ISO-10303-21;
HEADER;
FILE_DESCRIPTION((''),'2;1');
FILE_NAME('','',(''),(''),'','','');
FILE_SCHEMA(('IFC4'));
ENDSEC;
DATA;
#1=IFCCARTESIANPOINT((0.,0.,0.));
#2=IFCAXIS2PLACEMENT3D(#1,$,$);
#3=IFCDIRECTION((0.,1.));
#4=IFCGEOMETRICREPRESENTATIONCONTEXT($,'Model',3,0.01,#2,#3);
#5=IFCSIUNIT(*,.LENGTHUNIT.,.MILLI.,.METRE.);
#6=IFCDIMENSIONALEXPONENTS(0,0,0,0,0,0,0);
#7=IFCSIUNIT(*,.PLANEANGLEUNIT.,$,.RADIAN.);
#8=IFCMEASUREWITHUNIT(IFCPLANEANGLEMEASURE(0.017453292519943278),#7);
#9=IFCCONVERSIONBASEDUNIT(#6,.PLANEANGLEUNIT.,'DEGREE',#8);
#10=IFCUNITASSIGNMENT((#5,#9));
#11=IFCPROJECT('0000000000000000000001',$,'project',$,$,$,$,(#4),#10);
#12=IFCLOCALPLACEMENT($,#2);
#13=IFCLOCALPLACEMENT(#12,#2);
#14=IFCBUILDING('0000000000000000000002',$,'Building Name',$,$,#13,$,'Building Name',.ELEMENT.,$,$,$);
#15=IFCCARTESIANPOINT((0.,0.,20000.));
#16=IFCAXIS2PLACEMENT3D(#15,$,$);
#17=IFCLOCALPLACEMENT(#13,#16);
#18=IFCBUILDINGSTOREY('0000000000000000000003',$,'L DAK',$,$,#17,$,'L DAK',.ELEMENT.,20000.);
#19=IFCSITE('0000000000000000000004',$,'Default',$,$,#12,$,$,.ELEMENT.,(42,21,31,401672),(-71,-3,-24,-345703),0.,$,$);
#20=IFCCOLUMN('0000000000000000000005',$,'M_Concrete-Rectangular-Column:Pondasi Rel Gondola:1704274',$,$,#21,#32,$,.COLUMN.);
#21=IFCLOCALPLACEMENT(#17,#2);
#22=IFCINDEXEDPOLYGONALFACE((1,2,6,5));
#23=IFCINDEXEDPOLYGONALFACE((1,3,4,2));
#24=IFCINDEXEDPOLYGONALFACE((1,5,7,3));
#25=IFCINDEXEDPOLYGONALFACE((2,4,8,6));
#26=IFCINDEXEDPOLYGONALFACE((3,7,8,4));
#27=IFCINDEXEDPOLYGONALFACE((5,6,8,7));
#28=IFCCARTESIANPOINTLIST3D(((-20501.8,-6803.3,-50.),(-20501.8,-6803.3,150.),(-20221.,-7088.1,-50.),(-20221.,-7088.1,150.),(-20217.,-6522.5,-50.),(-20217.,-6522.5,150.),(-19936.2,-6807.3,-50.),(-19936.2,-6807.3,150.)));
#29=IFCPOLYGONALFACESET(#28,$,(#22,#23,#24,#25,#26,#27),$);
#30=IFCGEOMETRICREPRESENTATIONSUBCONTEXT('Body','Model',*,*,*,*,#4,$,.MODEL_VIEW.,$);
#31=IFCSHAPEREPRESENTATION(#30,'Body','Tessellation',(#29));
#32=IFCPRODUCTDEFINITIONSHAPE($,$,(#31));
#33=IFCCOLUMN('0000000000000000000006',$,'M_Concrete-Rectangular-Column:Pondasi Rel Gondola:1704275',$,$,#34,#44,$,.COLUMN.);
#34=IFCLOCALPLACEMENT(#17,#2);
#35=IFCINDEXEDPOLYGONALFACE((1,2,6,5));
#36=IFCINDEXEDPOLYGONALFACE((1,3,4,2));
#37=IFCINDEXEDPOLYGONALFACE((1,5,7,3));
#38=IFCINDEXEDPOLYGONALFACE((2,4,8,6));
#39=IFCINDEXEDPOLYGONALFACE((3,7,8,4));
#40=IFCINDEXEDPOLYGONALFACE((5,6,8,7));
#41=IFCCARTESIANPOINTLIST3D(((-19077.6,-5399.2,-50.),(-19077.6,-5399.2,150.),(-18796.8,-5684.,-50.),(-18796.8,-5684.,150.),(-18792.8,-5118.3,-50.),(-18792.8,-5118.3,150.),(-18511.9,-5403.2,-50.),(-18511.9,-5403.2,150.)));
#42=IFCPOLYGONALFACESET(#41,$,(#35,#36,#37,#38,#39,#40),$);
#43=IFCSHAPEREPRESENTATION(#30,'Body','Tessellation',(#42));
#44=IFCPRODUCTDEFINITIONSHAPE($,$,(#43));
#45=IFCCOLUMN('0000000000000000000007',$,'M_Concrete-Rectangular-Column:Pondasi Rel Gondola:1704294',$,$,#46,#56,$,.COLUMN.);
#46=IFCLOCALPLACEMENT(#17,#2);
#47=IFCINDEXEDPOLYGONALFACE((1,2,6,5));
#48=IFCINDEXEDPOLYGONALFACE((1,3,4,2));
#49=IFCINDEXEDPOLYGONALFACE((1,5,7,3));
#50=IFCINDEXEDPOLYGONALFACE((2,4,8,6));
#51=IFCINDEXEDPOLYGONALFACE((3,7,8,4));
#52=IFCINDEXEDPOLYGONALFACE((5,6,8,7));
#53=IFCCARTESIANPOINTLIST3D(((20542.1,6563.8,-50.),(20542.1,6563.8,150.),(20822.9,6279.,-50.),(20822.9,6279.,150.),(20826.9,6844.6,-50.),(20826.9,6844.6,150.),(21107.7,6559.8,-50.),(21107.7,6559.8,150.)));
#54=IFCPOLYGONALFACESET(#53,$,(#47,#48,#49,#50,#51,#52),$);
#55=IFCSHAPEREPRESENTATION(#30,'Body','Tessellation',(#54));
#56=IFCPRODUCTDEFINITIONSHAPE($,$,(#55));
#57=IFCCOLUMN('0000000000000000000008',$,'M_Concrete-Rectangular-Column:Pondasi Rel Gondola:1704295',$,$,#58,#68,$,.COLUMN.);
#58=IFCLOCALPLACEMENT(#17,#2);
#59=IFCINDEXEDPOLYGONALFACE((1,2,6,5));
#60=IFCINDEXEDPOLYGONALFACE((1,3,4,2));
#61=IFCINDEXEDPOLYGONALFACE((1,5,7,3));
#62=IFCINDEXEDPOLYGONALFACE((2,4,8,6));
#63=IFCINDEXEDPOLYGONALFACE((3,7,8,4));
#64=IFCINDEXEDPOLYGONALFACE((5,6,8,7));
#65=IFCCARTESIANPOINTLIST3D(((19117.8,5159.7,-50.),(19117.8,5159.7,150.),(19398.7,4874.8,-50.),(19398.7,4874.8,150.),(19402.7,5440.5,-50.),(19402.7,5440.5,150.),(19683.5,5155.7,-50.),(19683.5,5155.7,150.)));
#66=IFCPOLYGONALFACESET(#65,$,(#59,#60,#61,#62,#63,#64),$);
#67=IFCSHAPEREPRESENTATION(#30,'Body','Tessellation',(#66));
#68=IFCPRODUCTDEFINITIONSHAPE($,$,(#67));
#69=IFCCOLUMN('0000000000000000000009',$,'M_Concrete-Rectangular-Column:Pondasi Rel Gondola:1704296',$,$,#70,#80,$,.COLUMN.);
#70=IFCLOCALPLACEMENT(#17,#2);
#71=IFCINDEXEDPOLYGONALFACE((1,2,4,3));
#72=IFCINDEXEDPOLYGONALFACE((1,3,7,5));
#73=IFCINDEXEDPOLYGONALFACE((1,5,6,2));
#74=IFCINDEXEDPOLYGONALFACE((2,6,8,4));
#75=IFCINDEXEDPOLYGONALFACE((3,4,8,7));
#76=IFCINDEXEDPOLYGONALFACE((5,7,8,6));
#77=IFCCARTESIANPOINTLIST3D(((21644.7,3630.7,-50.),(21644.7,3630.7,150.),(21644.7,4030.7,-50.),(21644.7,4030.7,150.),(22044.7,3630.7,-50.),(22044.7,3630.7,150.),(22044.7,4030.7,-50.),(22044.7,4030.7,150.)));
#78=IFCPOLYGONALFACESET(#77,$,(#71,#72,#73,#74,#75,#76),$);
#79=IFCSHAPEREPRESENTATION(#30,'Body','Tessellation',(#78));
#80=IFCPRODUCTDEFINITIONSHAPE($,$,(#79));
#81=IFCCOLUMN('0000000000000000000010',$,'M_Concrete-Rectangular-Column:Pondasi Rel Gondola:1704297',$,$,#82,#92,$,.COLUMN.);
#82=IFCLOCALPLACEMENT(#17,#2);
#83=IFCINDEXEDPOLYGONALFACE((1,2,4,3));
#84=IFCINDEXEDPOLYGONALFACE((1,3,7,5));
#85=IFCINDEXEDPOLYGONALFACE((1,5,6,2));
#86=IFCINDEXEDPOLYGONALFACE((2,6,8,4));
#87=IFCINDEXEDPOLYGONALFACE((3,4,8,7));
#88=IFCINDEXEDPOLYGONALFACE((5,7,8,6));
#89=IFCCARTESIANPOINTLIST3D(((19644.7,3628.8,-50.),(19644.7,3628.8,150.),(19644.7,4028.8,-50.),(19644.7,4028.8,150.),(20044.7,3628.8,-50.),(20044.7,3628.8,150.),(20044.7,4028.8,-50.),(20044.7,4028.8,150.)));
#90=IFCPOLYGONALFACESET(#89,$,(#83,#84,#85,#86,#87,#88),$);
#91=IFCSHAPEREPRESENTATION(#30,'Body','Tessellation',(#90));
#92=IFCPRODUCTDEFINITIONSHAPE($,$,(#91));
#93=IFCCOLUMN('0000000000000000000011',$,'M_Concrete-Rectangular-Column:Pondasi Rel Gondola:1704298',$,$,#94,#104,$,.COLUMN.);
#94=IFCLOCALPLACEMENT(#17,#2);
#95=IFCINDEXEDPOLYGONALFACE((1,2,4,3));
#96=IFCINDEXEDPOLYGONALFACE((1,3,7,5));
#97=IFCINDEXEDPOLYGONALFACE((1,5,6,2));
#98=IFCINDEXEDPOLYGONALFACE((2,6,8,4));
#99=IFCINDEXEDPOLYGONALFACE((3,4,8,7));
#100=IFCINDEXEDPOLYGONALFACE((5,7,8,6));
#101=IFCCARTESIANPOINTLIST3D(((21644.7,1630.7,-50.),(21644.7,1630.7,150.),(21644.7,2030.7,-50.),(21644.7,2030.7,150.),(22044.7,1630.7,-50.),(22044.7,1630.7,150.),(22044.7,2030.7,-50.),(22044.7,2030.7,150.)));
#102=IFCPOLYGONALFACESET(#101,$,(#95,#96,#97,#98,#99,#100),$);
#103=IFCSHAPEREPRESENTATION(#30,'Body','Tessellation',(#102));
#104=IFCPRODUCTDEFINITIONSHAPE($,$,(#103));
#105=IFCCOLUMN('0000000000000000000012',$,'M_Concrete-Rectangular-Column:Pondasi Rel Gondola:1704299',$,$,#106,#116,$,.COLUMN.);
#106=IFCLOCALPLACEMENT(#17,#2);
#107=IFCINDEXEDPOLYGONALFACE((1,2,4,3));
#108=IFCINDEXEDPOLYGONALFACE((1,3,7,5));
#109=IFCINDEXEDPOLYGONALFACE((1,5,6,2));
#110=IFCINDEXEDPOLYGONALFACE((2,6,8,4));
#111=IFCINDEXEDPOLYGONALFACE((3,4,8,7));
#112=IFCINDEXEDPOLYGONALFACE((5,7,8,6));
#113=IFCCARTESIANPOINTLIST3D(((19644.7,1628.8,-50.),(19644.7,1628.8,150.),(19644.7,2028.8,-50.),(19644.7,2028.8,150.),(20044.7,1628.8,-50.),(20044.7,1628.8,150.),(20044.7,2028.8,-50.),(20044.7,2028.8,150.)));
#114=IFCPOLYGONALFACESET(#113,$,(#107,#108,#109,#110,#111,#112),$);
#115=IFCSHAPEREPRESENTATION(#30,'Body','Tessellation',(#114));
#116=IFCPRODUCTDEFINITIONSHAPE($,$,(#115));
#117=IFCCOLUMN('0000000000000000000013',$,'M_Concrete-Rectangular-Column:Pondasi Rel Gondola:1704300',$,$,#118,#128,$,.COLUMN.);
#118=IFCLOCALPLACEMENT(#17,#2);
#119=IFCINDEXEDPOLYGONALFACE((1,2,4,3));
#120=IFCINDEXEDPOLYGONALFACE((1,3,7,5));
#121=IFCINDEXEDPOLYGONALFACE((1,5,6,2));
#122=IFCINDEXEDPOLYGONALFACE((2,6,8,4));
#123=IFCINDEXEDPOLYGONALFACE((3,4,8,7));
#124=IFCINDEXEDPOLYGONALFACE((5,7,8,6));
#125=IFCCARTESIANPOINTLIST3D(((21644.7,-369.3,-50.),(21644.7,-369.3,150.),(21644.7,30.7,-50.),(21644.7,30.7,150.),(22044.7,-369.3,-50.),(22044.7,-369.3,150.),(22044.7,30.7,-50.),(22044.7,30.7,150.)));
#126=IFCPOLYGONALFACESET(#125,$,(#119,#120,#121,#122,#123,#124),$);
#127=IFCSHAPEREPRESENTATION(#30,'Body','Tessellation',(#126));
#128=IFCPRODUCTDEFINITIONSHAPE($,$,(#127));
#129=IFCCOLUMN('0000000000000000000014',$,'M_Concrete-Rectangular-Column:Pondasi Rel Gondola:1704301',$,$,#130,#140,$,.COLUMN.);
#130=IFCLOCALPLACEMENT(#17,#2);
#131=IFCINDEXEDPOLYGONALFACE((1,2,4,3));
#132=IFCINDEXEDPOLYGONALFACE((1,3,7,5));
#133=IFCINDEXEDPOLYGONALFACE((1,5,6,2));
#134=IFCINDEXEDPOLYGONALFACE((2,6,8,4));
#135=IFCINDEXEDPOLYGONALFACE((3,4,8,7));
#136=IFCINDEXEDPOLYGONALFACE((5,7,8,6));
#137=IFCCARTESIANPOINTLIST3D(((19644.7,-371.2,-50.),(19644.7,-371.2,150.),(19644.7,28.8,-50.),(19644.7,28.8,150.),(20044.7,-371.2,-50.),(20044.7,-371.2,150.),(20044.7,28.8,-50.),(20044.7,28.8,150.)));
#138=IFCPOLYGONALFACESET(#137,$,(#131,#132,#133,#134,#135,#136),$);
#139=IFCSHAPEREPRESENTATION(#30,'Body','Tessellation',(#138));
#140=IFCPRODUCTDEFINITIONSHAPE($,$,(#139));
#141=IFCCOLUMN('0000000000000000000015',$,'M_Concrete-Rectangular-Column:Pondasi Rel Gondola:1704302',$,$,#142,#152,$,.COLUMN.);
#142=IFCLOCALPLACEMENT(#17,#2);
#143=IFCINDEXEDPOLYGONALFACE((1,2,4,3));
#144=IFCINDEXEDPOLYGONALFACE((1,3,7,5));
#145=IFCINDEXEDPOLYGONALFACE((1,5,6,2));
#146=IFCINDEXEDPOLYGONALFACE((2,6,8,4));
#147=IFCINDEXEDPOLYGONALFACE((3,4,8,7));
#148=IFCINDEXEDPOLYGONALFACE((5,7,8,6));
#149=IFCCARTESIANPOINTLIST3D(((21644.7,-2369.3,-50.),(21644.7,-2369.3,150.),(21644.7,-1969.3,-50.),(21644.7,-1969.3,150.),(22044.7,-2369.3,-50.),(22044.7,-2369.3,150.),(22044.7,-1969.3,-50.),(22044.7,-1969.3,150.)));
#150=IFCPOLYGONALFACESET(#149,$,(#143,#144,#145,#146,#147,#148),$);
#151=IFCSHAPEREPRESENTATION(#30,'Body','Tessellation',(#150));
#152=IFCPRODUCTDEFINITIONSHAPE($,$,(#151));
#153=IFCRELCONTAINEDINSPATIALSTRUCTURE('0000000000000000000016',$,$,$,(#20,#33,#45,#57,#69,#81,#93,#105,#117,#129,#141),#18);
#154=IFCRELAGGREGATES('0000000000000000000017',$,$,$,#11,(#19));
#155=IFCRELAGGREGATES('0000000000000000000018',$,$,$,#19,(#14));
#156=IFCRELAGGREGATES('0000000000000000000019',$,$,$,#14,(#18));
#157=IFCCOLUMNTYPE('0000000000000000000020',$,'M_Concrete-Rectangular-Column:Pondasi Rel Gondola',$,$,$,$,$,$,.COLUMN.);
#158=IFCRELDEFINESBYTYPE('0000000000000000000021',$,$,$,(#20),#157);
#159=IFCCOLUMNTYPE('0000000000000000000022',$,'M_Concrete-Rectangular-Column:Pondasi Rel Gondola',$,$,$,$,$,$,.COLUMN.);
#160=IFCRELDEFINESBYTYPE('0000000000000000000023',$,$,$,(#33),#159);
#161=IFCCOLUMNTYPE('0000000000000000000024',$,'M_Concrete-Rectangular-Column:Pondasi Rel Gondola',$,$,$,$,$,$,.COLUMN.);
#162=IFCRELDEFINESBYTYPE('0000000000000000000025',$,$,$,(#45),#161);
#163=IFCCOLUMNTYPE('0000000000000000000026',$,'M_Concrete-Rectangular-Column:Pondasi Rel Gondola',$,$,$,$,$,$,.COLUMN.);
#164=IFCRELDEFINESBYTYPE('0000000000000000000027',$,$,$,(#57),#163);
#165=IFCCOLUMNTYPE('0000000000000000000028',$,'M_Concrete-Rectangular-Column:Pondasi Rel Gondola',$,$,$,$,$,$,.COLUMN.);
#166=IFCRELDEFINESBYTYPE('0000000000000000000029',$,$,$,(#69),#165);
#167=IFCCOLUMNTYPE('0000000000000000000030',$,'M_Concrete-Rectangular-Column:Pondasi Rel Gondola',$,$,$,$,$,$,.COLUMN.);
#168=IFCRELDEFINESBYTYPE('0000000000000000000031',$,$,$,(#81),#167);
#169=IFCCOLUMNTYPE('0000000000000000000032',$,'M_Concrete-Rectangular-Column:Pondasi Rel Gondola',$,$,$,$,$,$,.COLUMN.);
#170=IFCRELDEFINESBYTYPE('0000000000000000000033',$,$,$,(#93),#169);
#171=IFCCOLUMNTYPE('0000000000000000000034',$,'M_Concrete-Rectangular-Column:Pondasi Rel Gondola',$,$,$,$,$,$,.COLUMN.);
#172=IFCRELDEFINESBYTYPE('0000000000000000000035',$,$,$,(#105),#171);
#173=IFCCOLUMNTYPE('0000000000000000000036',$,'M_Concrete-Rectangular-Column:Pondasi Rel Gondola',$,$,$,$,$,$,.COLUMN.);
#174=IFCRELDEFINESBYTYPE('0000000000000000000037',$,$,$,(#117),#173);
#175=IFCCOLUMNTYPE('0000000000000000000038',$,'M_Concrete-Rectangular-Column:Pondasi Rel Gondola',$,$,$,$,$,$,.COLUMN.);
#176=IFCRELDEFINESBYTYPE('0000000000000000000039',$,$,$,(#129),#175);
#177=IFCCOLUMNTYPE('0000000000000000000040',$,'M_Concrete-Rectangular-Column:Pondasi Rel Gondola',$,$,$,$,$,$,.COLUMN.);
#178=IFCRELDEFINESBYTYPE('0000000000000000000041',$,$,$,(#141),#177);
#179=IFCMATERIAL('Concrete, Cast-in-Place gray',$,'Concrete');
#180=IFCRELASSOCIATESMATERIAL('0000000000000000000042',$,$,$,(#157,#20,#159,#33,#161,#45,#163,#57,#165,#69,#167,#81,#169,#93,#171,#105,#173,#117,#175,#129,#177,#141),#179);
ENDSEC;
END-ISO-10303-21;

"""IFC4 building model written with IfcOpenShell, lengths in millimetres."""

from ifc_helpers import new_model, entity, si_unit, converted_unit, direction, frame, origin, place, context, subcontext, project, spatial, indexed_curve, outline, extrude, source, transform, mapped, material, type_object, type_shapes, element, save


model = new_model("IFC4")

# Units and contexts
model_context = context("Model", 3, precision=0.01, world=origin(), true_north=direction((0.0, 1.0)))
body_context = subcontext(model_context, "Body", "Model", "MODEL_VIEW")
ifc_project = project(units=[si_unit("LENGTHUNIT", "METRE", prefix="MILLI"), converted_unit("PLANEANGLEUNIT", "DEGREE", entity("IfcPlaneAngleMeasure", 0.017453292519943278), si_unit("PLANEANGLEUNIT", "RADIAN"), dimensions=[0, 0, 0, 0, 0, 0, 0])], contexts=[model_context])

# Site, building, storey
site_placement = place(None, origin())
site = spatial("IfcSite", under=ifc_project, at=site_placement, Name="Default", CompositionType="ELEMENT", RefLatitude=(42, 21, 31, 401672), RefLongitude=(-71, -3, -24, -345703), RefElevation=0.0)
building_placement = place(site_placement, origin())
building = spatial("IfcBuilding", under=site, at=building_placement, Name="Building Name", LongName="Building Name", CompositionType="ELEMENT")
storey_placement = place(building_placement, frame((0.0, 0.0, 20000.0)))
storey = spatial("IfcBuildingStorey", under=building, at=storey_placement, Name="L DAK", LongName="L DAK", CompositionType="ELEMENT", Elevation=20000.0)

# Columns
ifc_material = material(Name="Concrete, Cast-in-Place gray", Category="Concrete")
column_type_1 = type_object("IfcColumnType", Name="M_Concrete-Rectangular-Column:Pondasi Rel Gondola", PredefinedType="COLUMN", material=ifc_material)
shared_shape_1 = source(origin(), body_context, "Body", "SweptSolid", [
    extrude(outline(indexed_curve([(-200.0, -200.0), (200.0, -200.0), (200.0, 200.0), (-200.0, 200.0), (-200.0, -200.0)], self_intersect=False)), frame((-20219.0, -6805.3, 19950.0), z_axis=(0.0, 0.0, 1.0), x_axis=(0.712114, 0.702064, 0.0)), (0.0, 0.0, 1.0), 200.0),
])
type_shapes(column_type_1, [shared_shape_1])
column_1_placement = place(storey_placement, frame((0.0, 0.0, -20000.0)))
element("IfcColumn", 1, at=column_1_placement, inside=storey, type_object=column_type_1, material=ifc_material, Name="M_Concrete-Rectangular-Column:Pondasi Rel Gondola:1704274", PredefinedType="COLUMN", context=body_context, shape_type="MappedRepresentation", body=[
    mapped(shared_shape_1, transform((0.0, 0.0, 0.0), scale=1.0)),
])
column_type_2 = type_object("IfcColumnType", Name="M_Concrete-Rectangular-Column:Pondasi Rel Gondola", PredefinedType="COLUMN", material=ifc_material)
shared_shape_2 = source(origin(), body_context, "Body", "SweptSolid", [
    extrude(outline(indexed_curve([(-200.0, -200.0), (200.0, -200.0), (200.0, 200.0), (-200.0, 200.0), (-200.0, -200.0)], self_intersect=False)), frame((-18794.8, -5401.2, 19950.0), z_axis=(0.0, 0.0, 1.0), x_axis=(0.712114, 0.702064, 0.0)), (0.0, 0.0, 1.0), 200.0),
])
type_shapes(column_type_2, [shared_shape_2])
column_2_placement = place(storey_placement, frame((0.0, 0.0, -20000.0)))
element("IfcColumn", 2, at=column_2_placement, inside=storey, type_object=column_type_2, material=ifc_material, Name="M_Concrete-Rectangular-Column:Pondasi Rel Gondola:1704275", PredefinedType="COLUMN", context=body_context, shape_type="MappedRepresentation", body=[
    mapped(shared_shape_2, transform((0.0, 0.0, 0.0), scale=1.0)),
])
column_type_3 = type_object("IfcColumnType", Name="M_Concrete-Rectangular-Column:Pondasi Rel Gondola", PredefinedType="COLUMN", material=ifc_material)
shared_shape_3 = source(origin(), body_context, "Body", "SweptSolid", [
    extrude(outline(indexed_curve([(-200.0, -200.0), (200.0, -200.0), (200.0, 200.0), (-200.0, 200.0), (-200.0, -200.0)], self_intersect=False)), frame((20824.9, 6561.8, 19950.0), z_axis=(0.0, 0.0, 1.0), x_axis=(-0.712114, -0.702064, 0.0)), (0.0, 0.0, 1.0), 200.0),
])
type_shapes(column_type_3, [shared_shape_3])
column_3_placement = place(storey_placement, frame((0.0, 0.0, -20000.0)))
element("IfcColumn", 3, at=column_3_placement, inside=storey, type_object=column_type_3, material=ifc_material, Name="M_Concrete-Rectangular-Column:Pondasi Rel Gondola:1704294", PredefinedType="COLUMN", context=body_context, shape_type="MappedRepresentation", body=[
    mapped(shared_shape_3, transform((0.0, 0.0, 0.0), scale=1.0)),
])
column_type_4 = type_object("IfcColumnType", Name="M_Concrete-Rectangular-Column:Pondasi Rel Gondola", PredefinedType="COLUMN", material=ifc_material)
shared_shape_4 = source(origin(), body_context, "Body", "SweptSolid", [
    extrude(outline(indexed_curve([(-200.0, -200.0), (200.0, -200.0), (200.0, 200.0), (-200.0, 200.0), (-200.0, -200.0)], self_intersect=False)), frame((19400.7, 5157.7, 19950.0), z_axis=(0.0, 0.0, 1.0), x_axis=(-0.712114, -0.702064, 0.0)), (0.0, 0.0, 1.0), 200.0),
])
type_shapes(column_type_4, [shared_shape_4])
column_4_placement = place(storey_placement, frame((0.0, 0.0, -20000.0)))
element("IfcColumn", 4, at=column_4_placement, inside=storey, type_object=column_type_4, material=ifc_material, Name="M_Concrete-Rectangular-Column:Pondasi Rel Gondola:1704295", PredefinedType="COLUMN", context=body_context, shape_type="MappedRepresentation", body=[
    mapped(shared_shape_4, transform((0.0, 0.0, 0.0), scale=1.0)),
])
column_type_5 = type_object("IfcColumnType", Name="M_Concrete-Rectangular-Column:Pondasi Rel Gondola", PredefinedType="COLUMN", material=ifc_material)
shared_shape_5 = source(origin(), body_context, "Body", "SweptSolid", [
    extrude(outline(indexed_curve([(-200.0, -200.0), (200.0, -200.0), (200.0, 200.0), (-200.0, 200.0), (-200.0, -200.0)], self_intersect=False)), frame((21844.7, 3830.7, 19950.0), z_axis=(0.0, 0.0, 1.0), x_axis=(0.0, -1.0, 0.0)), (0.0, 0.0, 1.0), 200.0),
])
type_shapes(column_type_5, [shared_shape_5])
column_5_placement = place(storey_placement, frame((0.0, 0.0, -20000.0)))
element("IfcColumn", 5, at=column_5_placement, inside=storey, type_object=column_type_5, material=ifc_material, Name="M_Concrete-Rectangular-Column:Pondasi Rel Gondola:1704296", PredefinedType="COLUMN", context=body_context, shape_type="MappedRepresentation", body=[
    mapped(shared_shape_5, transform((0.0, 0.0, 0.0), scale=1.0)),
])
column_type_6 = type_object("IfcColumnType", Name="M_Concrete-Rectangular-Column:Pondasi Rel Gondola", PredefinedType="COLUMN", material=ifc_material)
shared_shape_6 = source(origin(), body_context, "Body", "SweptSolid", [
    extrude(outline(indexed_curve([(-200.0, -200.0), (200.0, -200.0), (200.0, 200.0), (-200.0, 200.0), (-200.0, -200.0)], self_intersect=False)), frame((19844.7, 3828.8, 19950.0), z_axis=(0.0, 0.0, 1.0), x_axis=(0.0, -1.0, 0.0)), (0.0, 0.0, 1.0), 200.0),
])
type_shapes(column_type_6, [shared_shape_6])
column_6_placement = place(storey_placement, frame((0.0, 0.0, -20000.0)))
element("IfcColumn", 6, at=column_6_placement, inside=storey, type_object=column_type_6, material=ifc_material, Name="M_Concrete-Rectangular-Column:Pondasi Rel Gondola:1704297", PredefinedType="COLUMN", context=body_context, shape_type="MappedRepresentation", body=[
    mapped(shared_shape_6, transform((0.0, 0.0, 0.0), scale=1.0)),
])
column_type_7 = type_object("IfcColumnType", Name="M_Concrete-Rectangular-Column:Pondasi Rel Gondola", PredefinedType="COLUMN", material=ifc_material)
shared_shape_7 = source(origin(), body_context, "Body", "SweptSolid", [
    extrude(outline(indexed_curve([(-200.0, -200.0), (200.0, -200.0), (200.0, 200.0), (-200.0, 200.0), (-200.0, -200.0)], self_intersect=False)), frame((21844.7, 1830.7, 19950.0), z_axis=(0.0, 0.0, 1.0), x_axis=(0.0, -1.0, 0.0)), (0.0, 0.0, 1.0), 200.0),
])
type_shapes(column_type_7, [shared_shape_7])
column_7_placement = place(storey_placement, frame((0.0, 0.0, -20000.0)))
element("IfcColumn", 7, at=column_7_placement, inside=storey, type_object=column_type_7, material=ifc_material, Name="M_Concrete-Rectangular-Column:Pondasi Rel Gondola:1704298", PredefinedType="COLUMN", context=body_context, shape_type="MappedRepresentation", body=[
    mapped(shared_shape_7, transform((0.0, 0.0, 0.0), scale=1.0)),
])
column_type_8 = type_object("IfcColumnType", Name="M_Concrete-Rectangular-Column:Pondasi Rel Gondola", PredefinedType="COLUMN", material=ifc_material)
shared_shape_8 = source(origin(), body_context, "Body", "SweptSolid", [
    extrude(outline(indexed_curve([(-200.0, -200.0), (200.0, -200.0), (200.0, 200.0), (-200.0, 200.0), (-200.0, -200.0)], self_intersect=False)), frame((19844.7, 1828.8, 19950.0), z_axis=(0.0, 0.0, 1.0), x_axis=(0.0, -1.0, 0.0)), (0.0, 0.0, 1.0), 200.0),
])
type_shapes(column_type_8, [shared_shape_8])
column_8_placement = place(storey_placement, frame((0.0, 0.0, -20000.0)))
element("IfcColumn", 8, at=column_8_placement, inside=storey, type_object=column_type_8, material=ifc_material, Name="M_Concrete-Rectangular-Column:Pondasi Rel Gondola:1704299", PredefinedType="COLUMN", context=body_context, shape_type="MappedRepresentation", body=[
    mapped(shared_shape_8, transform((0.0, 0.0, 0.0), scale=1.0)),
])
column_type_9 = type_object("IfcColumnType", Name="M_Concrete-Rectangular-Column:Pondasi Rel Gondola", PredefinedType="COLUMN", material=ifc_material)
shared_shape_9 = source(origin(), body_context, "Body", "SweptSolid", [
    extrude(outline(indexed_curve([(-200.0, -200.0), (200.0, -200.0), (200.0, 200.0), (-200.0, 200.0), (-200.0, -200.0)], self_intersect=False)), frame((21844.7, -169.3, 19950.0), z_axis=(0.0, 0.0, 1.0), x_axis=(0.0, -1.0, 0.0)), (0.0, 0.0, 1.0), 200.0),
])
type_shapes(column_type_9, [shared_shape_9])
column_9_placement = place(storey_placement, frame((0.0, 0.0, -20000.0)))
element("IfcColumn", 9, at=column_9_placement, inside=storey, type_object=column_type_9, material=ifc_material, Name="M_Concrete-Rectangular-Column:Pondasi Rel Gondola:1704300", PredefinedType="COLUMN", context=body_context, shape_type="MappedRepresentation", body=[
    mapped(shared_shape_9, transform((0.0, 0.0, 0.0), scale=1.0)),
])
column_type_10 = type_object("IfcColumnType", Name="M_Concrete-Rectangular-Column:Pondasi Rel Gondola", PredefinedType="COLUMN", material=ifc_material)
shared_shape_10 = source(origin(), body_context, "Body", "SweptSolid", [
    extrude(outline(indexed_curve([(-200.0, -200.0), (200.0, -200.0), (200.0, 200.0), (-200.0, 200.0), (-200.0, -200.0)], self_intersect=False)), frame((19844.7, -171.2, 19950.0), z_axis=(0.0, 0.0, 1.0), x_axis=(0.0, -1.0, 0.0)), (0.0, 0.0, 1.0), 200.0),
])
type_shapes(column_type_10, [shared_shape_10])
column_10_placement = place(storey_placement, frame((0.0, 0.0, -20000.0)))
element("IfcColumn", 10, at=column_10_placement, inside=storey, type_object=column_type_10, material=ifc_material, Name="M_Concrete-Rectangular-Column:Pondasi Rel Gondola:1704301", PredefinedType="COLUMN", context=body_context, shape_type="MappedRepresentation", body=[
    mapped(shared_shape_10, transform((0.0, 0.0, 0.0), scale=1.0)),
])
column_type_11 = type_object("IfcColumnType", Name="M_Concrete-Rectangular-Column:Pondasi Rel Gondola", PredefinedType="COLUMN", material=ifc_material)
shared_shape_11 = source(origin(), body_context, "Body", "SweptSolid", [
    extrude(outline(indexed_curve([(-200.0, -200.0), (200.0, -200.0), (200.0, 200.0), (-200.0, 200.0), (-200.0, -200.0)], self_intersect=False)), frame((21844.7, -2169.3, 19950.0), z_axis=(0.0, 0.0, 1.0), x_axis=(0.0, -1.0, 0.0)), (0.0, 0.0, 1.0), 200.0),
])
type_shapes(column_type_11, [shared_shape_11])
column_11_placement = place(storey_placement, frame((0.0, 0.0, -20000.0)))
element("IfcColumn", 11, at=column_11_placement, inside=storey, type_object=column_type_11, material=ifc_material, Name="M_Concrete-Rectangular-Column:Pondasi Rel Gondola:1704302", PredefinedType="COLUMN", context=body_context, shape_type="MappedRepresentation", body=[
    mapped(shared_shape_11, transform((0.0, 0.0, 0.0), scale=1.0)),
])

save(model, "model.ifc")
